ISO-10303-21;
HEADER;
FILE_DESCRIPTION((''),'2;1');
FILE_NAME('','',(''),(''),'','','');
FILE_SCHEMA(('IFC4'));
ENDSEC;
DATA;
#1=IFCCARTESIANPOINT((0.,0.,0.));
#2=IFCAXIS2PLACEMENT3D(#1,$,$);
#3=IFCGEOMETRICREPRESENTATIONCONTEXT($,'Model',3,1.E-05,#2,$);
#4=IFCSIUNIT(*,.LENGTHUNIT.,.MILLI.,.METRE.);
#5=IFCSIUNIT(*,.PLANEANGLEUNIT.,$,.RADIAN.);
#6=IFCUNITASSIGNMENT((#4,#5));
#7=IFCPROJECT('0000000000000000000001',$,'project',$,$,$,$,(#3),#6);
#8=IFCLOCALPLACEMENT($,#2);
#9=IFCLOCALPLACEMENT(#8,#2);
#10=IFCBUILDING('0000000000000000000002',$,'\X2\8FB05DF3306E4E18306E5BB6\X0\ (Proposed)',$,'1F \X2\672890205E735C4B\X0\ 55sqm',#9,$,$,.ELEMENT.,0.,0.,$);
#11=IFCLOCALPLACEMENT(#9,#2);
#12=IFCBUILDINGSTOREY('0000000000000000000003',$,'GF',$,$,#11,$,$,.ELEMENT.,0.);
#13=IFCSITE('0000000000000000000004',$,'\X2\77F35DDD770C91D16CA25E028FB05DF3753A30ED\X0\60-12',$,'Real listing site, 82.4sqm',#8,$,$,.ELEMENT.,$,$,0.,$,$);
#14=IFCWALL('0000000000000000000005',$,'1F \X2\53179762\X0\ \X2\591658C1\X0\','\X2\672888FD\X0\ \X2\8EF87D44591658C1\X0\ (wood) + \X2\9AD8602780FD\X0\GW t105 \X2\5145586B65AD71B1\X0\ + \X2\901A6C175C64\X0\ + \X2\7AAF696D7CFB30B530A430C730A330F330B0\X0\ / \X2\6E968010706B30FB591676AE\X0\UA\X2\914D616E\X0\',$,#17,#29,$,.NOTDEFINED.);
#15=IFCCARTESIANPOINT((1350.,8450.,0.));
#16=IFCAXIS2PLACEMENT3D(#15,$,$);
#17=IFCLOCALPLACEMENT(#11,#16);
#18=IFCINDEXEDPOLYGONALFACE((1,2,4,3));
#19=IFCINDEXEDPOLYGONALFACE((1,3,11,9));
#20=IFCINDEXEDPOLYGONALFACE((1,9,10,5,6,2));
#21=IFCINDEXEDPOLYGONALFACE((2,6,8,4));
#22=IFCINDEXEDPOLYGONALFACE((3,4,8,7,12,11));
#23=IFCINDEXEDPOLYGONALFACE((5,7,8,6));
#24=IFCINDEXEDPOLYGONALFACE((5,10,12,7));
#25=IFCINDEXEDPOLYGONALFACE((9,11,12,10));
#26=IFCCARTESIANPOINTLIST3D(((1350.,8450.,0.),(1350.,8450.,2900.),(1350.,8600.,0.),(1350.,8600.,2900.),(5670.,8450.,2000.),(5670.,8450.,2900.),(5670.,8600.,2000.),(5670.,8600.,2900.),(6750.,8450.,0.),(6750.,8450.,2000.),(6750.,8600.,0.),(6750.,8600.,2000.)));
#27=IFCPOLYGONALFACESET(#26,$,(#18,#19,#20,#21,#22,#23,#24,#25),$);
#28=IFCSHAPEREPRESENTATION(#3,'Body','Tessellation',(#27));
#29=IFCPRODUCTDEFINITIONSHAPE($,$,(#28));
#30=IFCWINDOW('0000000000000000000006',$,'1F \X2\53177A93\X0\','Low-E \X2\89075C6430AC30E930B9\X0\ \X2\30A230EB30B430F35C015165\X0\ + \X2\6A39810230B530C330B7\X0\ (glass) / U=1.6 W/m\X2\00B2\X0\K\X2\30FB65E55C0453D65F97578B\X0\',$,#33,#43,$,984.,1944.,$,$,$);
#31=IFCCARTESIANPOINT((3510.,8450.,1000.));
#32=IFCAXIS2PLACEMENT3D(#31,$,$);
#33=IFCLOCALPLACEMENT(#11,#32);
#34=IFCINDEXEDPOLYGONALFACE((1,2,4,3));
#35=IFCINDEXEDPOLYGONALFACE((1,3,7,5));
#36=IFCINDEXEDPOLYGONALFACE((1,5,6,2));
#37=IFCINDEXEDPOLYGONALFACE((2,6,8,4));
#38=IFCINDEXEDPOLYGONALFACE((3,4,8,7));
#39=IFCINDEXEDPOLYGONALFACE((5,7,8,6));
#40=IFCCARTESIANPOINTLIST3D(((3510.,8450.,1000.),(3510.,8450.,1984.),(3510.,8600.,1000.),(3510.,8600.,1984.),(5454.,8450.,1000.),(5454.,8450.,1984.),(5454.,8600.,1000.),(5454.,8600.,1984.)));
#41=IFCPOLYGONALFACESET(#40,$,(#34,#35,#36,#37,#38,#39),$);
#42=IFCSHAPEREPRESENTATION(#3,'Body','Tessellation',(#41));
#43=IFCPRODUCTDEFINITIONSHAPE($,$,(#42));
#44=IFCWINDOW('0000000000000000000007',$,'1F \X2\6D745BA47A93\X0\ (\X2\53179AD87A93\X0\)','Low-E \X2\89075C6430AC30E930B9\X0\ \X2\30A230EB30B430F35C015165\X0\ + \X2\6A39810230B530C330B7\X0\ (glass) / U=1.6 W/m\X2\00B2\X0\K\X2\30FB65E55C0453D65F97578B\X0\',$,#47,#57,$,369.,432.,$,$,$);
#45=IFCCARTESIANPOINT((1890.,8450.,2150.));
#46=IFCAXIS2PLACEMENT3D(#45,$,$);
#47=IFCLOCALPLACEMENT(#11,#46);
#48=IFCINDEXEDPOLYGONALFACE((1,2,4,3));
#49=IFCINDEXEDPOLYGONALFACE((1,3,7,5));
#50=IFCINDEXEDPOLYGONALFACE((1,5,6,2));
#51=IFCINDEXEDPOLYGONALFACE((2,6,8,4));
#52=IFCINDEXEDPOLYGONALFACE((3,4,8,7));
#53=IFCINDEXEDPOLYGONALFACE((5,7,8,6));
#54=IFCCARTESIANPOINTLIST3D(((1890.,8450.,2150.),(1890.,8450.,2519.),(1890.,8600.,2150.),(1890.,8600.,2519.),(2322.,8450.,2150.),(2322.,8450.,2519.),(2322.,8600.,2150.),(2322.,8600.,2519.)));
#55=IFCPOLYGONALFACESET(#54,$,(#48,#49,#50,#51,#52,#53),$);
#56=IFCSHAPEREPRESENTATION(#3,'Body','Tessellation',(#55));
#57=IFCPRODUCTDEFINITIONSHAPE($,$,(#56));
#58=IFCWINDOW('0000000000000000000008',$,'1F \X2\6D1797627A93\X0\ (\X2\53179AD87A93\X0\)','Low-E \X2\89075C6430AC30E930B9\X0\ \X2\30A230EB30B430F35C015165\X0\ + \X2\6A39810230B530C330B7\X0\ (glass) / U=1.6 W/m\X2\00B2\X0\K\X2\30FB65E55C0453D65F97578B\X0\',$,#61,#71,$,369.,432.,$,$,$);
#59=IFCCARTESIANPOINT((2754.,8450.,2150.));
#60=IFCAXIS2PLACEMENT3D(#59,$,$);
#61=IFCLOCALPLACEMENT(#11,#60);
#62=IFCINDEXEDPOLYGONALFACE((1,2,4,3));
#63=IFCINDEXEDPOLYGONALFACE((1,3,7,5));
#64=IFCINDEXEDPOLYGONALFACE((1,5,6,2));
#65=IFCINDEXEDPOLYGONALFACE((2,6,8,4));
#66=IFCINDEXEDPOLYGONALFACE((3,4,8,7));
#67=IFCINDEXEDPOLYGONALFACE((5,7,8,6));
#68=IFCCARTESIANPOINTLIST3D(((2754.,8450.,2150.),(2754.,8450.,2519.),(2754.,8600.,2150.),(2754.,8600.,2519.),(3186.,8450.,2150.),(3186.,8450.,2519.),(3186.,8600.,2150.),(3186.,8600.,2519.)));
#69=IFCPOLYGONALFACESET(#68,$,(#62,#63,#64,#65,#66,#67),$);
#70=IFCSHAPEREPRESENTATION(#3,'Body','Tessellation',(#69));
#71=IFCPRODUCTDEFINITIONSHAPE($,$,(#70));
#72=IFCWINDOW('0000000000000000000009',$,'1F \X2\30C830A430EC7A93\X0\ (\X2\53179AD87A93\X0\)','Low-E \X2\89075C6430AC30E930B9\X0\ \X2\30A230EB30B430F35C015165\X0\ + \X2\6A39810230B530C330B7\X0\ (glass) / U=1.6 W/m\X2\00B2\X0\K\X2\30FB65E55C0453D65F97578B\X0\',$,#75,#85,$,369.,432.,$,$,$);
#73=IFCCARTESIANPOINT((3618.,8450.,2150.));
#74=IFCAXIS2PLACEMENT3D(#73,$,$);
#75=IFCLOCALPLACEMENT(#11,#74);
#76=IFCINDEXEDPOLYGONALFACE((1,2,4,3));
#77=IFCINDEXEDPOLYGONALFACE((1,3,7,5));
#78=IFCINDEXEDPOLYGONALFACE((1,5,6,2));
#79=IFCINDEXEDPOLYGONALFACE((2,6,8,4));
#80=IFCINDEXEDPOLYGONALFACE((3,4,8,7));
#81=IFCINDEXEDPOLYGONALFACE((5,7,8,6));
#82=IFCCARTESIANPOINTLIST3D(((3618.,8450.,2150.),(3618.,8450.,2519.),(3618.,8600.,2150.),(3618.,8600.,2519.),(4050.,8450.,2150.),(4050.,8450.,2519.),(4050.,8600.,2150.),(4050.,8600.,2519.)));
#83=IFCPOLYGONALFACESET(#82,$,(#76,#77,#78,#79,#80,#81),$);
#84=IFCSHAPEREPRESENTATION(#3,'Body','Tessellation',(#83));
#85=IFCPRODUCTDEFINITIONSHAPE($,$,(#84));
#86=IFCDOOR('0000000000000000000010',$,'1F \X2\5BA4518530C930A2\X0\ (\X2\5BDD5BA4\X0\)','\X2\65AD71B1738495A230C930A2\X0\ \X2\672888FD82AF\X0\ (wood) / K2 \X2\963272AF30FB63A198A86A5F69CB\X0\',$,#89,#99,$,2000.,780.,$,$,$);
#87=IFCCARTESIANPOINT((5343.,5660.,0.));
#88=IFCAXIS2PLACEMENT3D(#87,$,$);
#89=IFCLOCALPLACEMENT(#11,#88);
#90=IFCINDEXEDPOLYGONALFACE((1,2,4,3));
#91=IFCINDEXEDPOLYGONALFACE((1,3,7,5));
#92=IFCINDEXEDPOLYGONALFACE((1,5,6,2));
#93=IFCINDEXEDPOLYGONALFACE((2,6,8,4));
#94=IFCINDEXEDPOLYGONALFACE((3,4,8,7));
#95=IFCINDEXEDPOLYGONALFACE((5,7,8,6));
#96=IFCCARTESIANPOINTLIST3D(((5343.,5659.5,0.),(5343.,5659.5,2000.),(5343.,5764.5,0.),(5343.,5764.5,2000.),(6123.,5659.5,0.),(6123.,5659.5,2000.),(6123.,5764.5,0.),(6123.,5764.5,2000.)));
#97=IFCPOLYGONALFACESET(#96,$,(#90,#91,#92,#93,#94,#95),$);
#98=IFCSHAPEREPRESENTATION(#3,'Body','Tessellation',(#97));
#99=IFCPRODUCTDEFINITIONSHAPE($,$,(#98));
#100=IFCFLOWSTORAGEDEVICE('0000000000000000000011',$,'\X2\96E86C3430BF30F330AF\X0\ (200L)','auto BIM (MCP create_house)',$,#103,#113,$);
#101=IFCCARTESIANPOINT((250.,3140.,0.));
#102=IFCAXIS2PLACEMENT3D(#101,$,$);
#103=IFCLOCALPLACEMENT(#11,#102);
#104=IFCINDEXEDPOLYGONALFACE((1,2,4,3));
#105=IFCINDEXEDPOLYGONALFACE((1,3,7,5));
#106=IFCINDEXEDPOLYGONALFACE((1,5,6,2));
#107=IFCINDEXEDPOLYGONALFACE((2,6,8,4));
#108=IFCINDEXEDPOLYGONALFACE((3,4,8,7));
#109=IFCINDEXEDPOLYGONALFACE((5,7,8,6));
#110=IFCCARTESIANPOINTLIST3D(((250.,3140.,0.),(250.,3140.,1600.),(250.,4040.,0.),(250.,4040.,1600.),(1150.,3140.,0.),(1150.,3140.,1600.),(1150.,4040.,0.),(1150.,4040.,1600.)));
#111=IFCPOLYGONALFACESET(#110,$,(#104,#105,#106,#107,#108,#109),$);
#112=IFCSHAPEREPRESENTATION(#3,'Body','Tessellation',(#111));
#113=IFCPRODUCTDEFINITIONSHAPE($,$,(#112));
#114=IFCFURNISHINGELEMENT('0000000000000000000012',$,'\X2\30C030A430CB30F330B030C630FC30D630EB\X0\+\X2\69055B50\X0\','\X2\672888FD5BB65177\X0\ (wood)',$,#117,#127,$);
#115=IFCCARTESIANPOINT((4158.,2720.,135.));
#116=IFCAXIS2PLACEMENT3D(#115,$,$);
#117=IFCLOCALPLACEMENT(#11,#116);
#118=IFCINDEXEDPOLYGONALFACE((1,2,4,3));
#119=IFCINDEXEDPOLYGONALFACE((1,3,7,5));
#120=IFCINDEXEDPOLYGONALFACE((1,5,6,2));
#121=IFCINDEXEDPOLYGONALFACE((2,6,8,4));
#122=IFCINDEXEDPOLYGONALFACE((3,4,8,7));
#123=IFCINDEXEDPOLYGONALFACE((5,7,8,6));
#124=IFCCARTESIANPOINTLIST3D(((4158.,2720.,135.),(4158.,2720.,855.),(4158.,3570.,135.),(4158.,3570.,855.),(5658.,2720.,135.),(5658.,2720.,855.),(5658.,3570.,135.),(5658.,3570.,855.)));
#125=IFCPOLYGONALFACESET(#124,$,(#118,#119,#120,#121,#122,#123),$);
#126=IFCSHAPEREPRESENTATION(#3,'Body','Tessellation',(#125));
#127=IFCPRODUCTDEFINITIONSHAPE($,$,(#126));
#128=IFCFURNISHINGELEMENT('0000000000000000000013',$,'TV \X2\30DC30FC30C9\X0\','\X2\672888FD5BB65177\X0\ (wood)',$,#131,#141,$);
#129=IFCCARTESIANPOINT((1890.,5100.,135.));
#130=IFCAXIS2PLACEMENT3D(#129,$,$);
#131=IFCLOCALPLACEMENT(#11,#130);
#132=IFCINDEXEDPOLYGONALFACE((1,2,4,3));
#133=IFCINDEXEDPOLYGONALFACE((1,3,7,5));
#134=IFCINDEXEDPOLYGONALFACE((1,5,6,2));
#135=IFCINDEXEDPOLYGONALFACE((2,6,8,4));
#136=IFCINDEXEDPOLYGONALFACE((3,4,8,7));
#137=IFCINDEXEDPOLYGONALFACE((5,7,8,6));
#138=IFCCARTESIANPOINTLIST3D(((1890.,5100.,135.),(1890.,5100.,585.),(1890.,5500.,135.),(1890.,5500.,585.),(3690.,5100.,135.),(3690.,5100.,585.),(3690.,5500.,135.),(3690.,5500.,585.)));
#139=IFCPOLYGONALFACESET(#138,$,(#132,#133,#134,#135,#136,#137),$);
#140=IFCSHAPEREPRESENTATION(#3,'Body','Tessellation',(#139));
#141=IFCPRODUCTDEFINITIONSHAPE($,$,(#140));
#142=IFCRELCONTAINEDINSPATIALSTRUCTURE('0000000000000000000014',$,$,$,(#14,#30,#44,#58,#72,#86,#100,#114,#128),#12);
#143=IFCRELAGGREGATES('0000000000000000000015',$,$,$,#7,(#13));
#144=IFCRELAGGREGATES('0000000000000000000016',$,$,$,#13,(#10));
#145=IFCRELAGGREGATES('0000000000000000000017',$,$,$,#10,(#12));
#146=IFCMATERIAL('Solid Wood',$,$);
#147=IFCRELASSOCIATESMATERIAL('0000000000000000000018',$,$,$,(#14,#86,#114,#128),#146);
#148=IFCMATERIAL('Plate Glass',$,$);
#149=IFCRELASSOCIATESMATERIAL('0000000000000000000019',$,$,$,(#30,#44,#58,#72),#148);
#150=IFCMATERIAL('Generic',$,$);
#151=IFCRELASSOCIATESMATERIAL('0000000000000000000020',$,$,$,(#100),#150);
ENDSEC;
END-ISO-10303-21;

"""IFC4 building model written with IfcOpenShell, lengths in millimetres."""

from ifc_helpers import new_model, si_unit, frame, frame_2d, origin, place, context, project, spatial, rectangle, extrude, material, element, fill, save


model = new_model("IFC4")

# Units and contexts
model_context = context("Model", 3, precision=1e-05, world=origin())
ifc_project = project(units=[si_unit("LENGTHUNIT", "METRE", prefix="MILLI"), si_unit("PLANEANGLEUNIT", "RADIAN")], contexts=[model_context])

# Site, building, storey
site_placement = place(None, origin())
site = spatial("IfcSite", under=ifc_project, at=site_placement, Name="石川県金沢市辰巳町ロ60-12", ObjectType="Real listing site, 82.4sqm", CompositionType="ELEMENT", RefElevation=0.0)
building_placement = place(site_placement, origin())
building = spatial("IfcBuilding", under=site, at=building_placement, Name="辰巳の丘の家 (Proposed)", ObjectType="1F 木造平屋 55sqm", CompositionType="ELEMENT", ElevationOfRefHeight=0.0, ElevationOfTerrain=0.0)
storey_placement = place(building_placement, origin())
storey = spatial("IfcBuildingStorey", under=building, at=storey_placement, Name="GF", CompositionType="ELEMENT", Elevation=0.0)

# Wall, openings, windows
ifc_material_1 = material(Name="Solid Wood")
wall_1_placement = place(storey_placement, frame((1350.0, 8450.0, 0.0)))
wall_1 = element("IfcWall", 1, at=wall_1_placement, inside=storey, material=ifc_material_1, Name="1F 北面 外壁", Description="木製 軸組外壁 (wood) + 高性能GW t105 充填断熱 + 通気層 + 窯業系サイディング / 準耐火・外皮UA配慮", PredefinedType="NOTDEFINED", context=model_context, shape_type="SweptSolid", body=[
    extrude(rectangle(XDim=5400.0, YDim=150.0, at=frame_2d((2700.0, 75.0))), frame((1350.0, 8450.0, 0.0)), (0.0, 0.0, 1.0), 2900.0),
])
opening_1_placement = place(storey_placement, frame((3510.0, 8450.0, 1000.0)))
opening_1 = element("IfcOpeningElement", 2, at=opening_1_placement, cuts=wall_1, PredefinedType="NOTDEFINED", context=model_context, shape_type="SweptSolid", body=[
    extrude(rectangle(XDim=1944.0, YDim=150.0, at=frame_2d((972.0, 75.0))), frame((3510.0, 8450.0, 1000.0)), (0.0, 0.0, 1.0), 984.0),
])
opening_2_placement = place(storey_placement, frame((1890.0, 8450.0, 2150.0)))
opening_2 = element("IfcOpeningElement", 3, at=opening_2_placement, cuts=wall_1, PredefinedType="NOTDEFINED", context=model_context, shape_type="SweptSolid", body=[
    extrude(rectangle(XDim=432.0, YDim=150.0, at=frame_2d((216.0, 75.0))), frame((1890.0, 8450.0, 2150.0)), (0.0, 0.0, 1.0), 369.0),
])
opening_3_placement = place(storey_placement, frame((2754.0, 8450.0, 2150.0)))
opening_3 = element("IfcOpeningElement", 4, at=opening_3_placement, cuts=wall_1, PredefinedType="NOTDEFINED", context=model_context, shape_type="SweptSolid", body=[
    extrude(rectangle(XDim=432.0, YDim=150.0, at=frame_2d((216.0, 75.0))), frame((2754.0, 8450.0, 2150.0)), (0.0, 0.0, 1.0), 369.0),
])
opening_4_placement = place(storey_placement, frame((3618.0, 8450.0, 2150.0)))
opening_4 = element("IfcOpeningElement", 5, at=opening_4_placement, cuts=wall_1, PredefinedType="NOTDEFINED", context=model_context, shape_type="SweptSolid", body=[
    extrude(rectangle(XDim=432.0, YDim=150.0, at=frame_2d((216.0, 75.0))), frame((3618.0, 8450.0, 2150.0)), (0.0, 0.0, 1.0), 369.0),
])
ifc_material_2 = material(Name="Plate Glass")
window_1_placement = place(storey_placement, frame((3510.0, 8450.0, 1000.0)))
window_1 = element("IfcWindow", 6, at=window_1_placement, inside=storey, material=ifc_material_2, Name="1F 北窓", Description="Low-E 複層ガラス アルゴン封入 + 樹脂サッシ (glass) / U=1.6 W/m²K・日射取得型", OverallHeight=984.0, OverallWidth=1944.0, context=model_context, shape_type="SweptSolid", body=[
    extrude(rectangle(XDim=1944.0, YDim=150.0, at=frame_2d((972.0, 75.0))), frame((3510.0, 8450.0, 1000.0)), (0.0, 0.0, 1.0), 984.0),
])
fill(opening_1, window_1)
window_2_placement = place(storey_placement, frame((1890.0, 8450.0, 2150.0)))
window_2 = element("IfcWindow", 7, at=window_2_placement, inside=storey, material=ifc_material_2, Name="1F 浴室窓 (北高窓)", Description="Low-E 複層ガラス アルゴン封入 + 樹脂サッシ (glass) / U=1.6 W/m²K・日射取得型", OverallHeight=369.0, OverallWidth=432.0, context=model_context, shape_type="SweptSolid", body=[
    extrude(rectangle(XDim=432.0, YDim=150.0, at=frame_2d((216.0, 75.0))), frame((1890.0, 8450.0, 2150.0)), (0.0, 0.0, 1.0), 369.0),
])
fill(opening_2, window_2)
window_3_placement = place(storey_placement, frame((2754.0, 8450.0, 2150.0)))
window_3 = element("IfcWindow", 8, at=window_3_placement, inside=storey, material=ifc_material_2, Name="1F 洗面窓 (北高窓)", Description="Low-E 複層ガラス アルゴン封入 + 樹脂サッシ (glass) / U=1.6 W/m²K・日射取得型", OverallHeight=369.0, OverallWidth=432.0, context=model_context, shape_type="SweptSolid", body=[
    extrude(rectangle(XDim=432.0, YDim=150.0, at=frame_2d((216.0, 75.0))), frame((2754.0, 8450.0, 2150.0)), (0.0, 0.0, 1.0), 369.0),
])
fill(opening_3, window_3)
window_4_placement = place(storey_placement, frame((3618.0, 8450.0, 2150.0)))
window_4 = element("IfcWindow", 9, at=window_4_placement, inside=storey, material=ifc_material_2, Name="1F トイレ窓 (北高窓)", Description="Low-E 複層ガラス アルゴン封入 + 樹脂サッシ (glass) / U=1.6 W/m²K・日射取得型", OverallHeight=369.0, OverallWidth=432.0, context=model_context, shape_type="SweptSolid", body=[
    extrude(rectangle(XDim=432.0, YDim=150.0, at=frame_2d((216.0, 75.0))), frame((3618.0, 8450.0, 2150.0)), (0.0, 0.0, 1.0), 369.0),
])
fill(opening_4, window_4)

# Door
door_1_placement = place(storey_placement, frame((5343.0, 5660.0, 0.0)))
element("IfcDoor", 10, at=door_1_placement, inside=storey, material=ifc_material_1, Name="1F 室内ドア (寝室)", Description="断熱玄関ドア 木製芯 (wood) / K2 防犯・採風機構", OverallHeight=2000.0, OverallWidth=780.0, context=model_context, shape_type="SweptSolid", body=[
    extrude(rectangle(XDim=780.0, YDim=105.0, at=frame_2d((390.0, 52.0))), frame((5343.0, 5660.0, 0.0)), (0.0, 0.0, 1.0), 2000.0),
])

# Flow storage device
ifc_material_3 = material(Name="Generic")
flow_storage_device_placement = place(storey_placement, frame((250.0, 3140.0, 0.0)))
element("IfcFlowStorageDevice", 11, at=flow_storage_device_placement, inside=storey, material=ifc_material_3, Name="雨水タンク (200L)", Description="auto BIM (MCP create_house)", context=model_context, shape_type="SweptSolid", body=[
    extrude(rectangle(XDim=900.0, YDim=900.0, at=frame_2d((450.0, 450.0))), frame((250.0, 3140.0, 0.0)), (0.0, 0.0, 1.0), 1600.0),
])

# Furnishing elements
furnishing_1_placement = place(storey_placement, frame((4158.0, 2720.0, 135.0)))
element("IfcFurnishingElement", 12, at=furnishing_1_placement, inside=storey, material=ifc_material_1, Name="ダイニングテーブル+椅子", Description="木製家具 (wood)", context=model_context, shape_type="SweptSolid", body=[
    extrude(rectangle(XDim=1500.0, YDim=850.0, at=frame_2d((750.0, 425.0))), frame((4158.0, 2720.0, 135.0)), (0.0, 0.0, 1.0), 720.0),
])
furnishing_2_placement = place(storey_placement, frame((1890.0, 5100.0, 135.0)))
element("IfcFurnishingElement", 13, at=furnishing_2_placement, inside=storey, material=ifc_material_1, Name="TV ボード", Description="木製家具 (wood)", context=model_context, shape_type="SweptSolid", body=[
    extrude(rectangle(XDim=1800.0, YDim=400.0, at=frame_2d((900.0, 200.0))), frame((1890.0, 5100.0, 135.0)), (0.0, 0.0, 1.0), 450.0),
])

save(model, "model.ifc")
